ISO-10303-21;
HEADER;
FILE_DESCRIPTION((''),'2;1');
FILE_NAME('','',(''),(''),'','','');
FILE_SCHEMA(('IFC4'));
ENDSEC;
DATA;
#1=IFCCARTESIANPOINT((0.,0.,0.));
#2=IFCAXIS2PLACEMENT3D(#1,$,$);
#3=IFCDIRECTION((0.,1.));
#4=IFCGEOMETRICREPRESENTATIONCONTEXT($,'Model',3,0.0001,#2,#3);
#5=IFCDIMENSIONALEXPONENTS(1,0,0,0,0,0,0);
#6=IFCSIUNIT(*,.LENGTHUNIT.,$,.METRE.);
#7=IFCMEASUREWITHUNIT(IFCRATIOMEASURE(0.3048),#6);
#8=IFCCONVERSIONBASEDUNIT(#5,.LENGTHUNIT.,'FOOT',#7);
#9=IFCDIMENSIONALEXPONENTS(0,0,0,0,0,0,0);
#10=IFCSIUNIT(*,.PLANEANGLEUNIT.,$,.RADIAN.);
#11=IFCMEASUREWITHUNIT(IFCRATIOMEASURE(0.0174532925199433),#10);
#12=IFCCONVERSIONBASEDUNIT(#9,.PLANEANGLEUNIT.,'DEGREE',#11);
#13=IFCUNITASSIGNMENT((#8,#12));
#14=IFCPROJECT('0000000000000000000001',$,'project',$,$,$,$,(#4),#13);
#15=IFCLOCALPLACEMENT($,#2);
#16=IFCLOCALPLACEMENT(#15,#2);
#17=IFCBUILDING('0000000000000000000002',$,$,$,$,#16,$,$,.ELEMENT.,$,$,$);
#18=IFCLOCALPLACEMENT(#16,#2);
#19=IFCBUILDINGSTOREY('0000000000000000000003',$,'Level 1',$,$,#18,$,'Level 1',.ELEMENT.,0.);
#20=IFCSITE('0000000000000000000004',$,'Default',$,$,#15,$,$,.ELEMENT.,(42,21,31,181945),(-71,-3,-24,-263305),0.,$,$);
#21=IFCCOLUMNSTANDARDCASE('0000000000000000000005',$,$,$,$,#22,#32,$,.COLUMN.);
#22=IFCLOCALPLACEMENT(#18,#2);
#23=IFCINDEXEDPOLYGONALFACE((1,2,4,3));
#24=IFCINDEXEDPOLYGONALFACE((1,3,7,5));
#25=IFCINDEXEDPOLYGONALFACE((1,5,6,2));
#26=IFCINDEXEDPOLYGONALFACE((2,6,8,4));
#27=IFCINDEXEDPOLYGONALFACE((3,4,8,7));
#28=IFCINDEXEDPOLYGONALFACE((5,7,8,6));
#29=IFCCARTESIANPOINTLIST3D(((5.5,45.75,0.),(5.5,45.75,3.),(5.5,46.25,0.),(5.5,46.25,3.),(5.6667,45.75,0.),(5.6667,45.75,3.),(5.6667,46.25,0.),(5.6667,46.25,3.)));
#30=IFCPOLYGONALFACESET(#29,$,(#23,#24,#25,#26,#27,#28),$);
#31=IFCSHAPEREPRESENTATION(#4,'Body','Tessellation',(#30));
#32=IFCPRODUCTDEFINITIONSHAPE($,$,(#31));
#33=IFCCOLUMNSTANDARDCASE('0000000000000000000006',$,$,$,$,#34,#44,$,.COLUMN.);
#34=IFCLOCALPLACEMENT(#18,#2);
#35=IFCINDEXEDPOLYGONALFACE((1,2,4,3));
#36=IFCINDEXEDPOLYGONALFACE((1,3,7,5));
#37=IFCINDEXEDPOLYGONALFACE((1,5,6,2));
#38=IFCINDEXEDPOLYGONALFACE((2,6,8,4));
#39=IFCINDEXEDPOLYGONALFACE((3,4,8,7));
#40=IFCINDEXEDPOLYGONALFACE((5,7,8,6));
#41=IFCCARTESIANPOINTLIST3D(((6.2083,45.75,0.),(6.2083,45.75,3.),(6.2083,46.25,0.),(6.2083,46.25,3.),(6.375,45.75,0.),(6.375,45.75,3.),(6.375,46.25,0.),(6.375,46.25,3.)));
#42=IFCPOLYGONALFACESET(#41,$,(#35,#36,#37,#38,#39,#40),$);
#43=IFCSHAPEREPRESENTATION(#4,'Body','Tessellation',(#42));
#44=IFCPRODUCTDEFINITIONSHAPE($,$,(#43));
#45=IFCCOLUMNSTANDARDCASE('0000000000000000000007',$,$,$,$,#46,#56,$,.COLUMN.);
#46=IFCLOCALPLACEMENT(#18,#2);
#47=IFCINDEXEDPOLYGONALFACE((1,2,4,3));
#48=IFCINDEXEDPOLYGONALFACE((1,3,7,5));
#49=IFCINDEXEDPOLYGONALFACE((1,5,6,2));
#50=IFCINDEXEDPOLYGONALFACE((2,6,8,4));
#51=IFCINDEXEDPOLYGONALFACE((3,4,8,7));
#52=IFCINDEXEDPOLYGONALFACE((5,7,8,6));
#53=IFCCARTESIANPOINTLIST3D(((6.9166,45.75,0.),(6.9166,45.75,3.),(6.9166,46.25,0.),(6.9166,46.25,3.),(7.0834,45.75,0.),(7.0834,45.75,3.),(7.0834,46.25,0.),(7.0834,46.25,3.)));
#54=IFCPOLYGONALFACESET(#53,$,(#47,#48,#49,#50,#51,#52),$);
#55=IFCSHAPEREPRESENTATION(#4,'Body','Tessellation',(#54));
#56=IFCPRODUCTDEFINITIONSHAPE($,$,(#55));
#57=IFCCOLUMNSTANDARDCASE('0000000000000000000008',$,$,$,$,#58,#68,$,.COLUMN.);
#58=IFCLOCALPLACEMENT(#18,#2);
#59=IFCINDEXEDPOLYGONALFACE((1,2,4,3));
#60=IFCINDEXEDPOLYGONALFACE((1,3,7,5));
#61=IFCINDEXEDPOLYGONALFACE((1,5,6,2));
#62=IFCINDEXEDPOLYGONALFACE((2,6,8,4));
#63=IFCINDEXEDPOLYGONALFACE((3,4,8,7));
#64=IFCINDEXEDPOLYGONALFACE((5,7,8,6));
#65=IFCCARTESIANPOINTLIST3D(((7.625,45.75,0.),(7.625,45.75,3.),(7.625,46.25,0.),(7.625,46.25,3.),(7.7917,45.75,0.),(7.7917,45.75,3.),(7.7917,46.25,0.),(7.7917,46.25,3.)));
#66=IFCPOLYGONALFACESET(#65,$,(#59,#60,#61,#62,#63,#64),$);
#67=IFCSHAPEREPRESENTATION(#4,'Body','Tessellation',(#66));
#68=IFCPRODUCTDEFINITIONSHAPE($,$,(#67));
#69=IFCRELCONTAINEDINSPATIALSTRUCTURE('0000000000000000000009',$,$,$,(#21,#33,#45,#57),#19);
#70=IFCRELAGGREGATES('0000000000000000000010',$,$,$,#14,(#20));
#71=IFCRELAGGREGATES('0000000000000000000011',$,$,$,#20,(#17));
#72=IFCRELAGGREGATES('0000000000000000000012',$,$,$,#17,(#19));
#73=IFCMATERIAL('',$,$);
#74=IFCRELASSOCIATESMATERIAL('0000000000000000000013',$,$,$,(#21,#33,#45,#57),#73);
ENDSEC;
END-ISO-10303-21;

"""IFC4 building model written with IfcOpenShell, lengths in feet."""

from ifc_helpers import new_model, entity, si_unit, converted_unit, direction, frame, origin, place, context, project, spatial, rectangle, extrude, material, element, save


model = new_model("IFC4")

# Units and contexts
model_context = context("Model", 3, precision=0.0001, world=origin(), true_north=direction((0.0, 1.0)))
ifc_project = project(units=[converted_unit("LENGTHUNIT", "FOOT", entity("IfcRatioMeasure", 0.3048), si_unit("LENGTHUNIT", "METRE"), dimensions=[1, 0, 0, 0, 0, 0, 0]), converted_unit("PLANEANGLEUNIT", "DEGREE", entity("IfcRatioMeasure", 0.0174532925199433), si_unit("PLANEANGLEUNIT", "RADIAN"), dimensions=[0, 0, 0, 0, 0, 0, 0])], contexts=[model_context])

# Site, building, storey
site_placement = place(None, origin())
site = spatial("IfcSite", under=ifc_project, at=site_placement, Name="Default", CompositionType="ELEMENT", RefLatitude=(42, 21, 31, 181945), RefLongitude=(-71, -3, -24, -263305), RefElevation=0.0)
building_placement = place(site_placement, origin())
building = spatial("IfcBuilding", under=site, at=building_placement, CompositionType="ELEMENT")
storey_placement = place(building_placement, origin())
storey = spatial("IfcBuildingStorey", under=building, at=storey_placement, Name="Level 1", LongName="Level 1", CompositionType="ELEMENT", Elevation=0.0)

# Columns
placement_1 = place(storey_placement, frame((-0.25, 46.0, 0.0)))
ifc_material_1 = material(Name="")
for number, where, z_axis, x_axis in (
    (1, (5.8334, 0.0, 0.0), (0.0, 0.0, 1.0), (1.0, 0.0, 0.0)),
    (2, (6.5417, 0.0, 0.0), (0.0, 0.0, 1.0), (1.0, 0.0, 0.0)),
    (3, (7.25, 0.0, 0.0), (0.0, 0.0, 1.0), (1.0, 0.0, 0.0)),
    (4, (7.9583, 0.0, 0.0), (0.0, 0.0, 1.0), (1.0, 0.0, 0.0)),
):
    element("IfcColumnStandardCase", number, at=place(placement_1, frame(where, z_axis=z_axis, x_axis=x_axis)), inside=storey, material=ifc_material_1, PredefinedType="COLUMN", context=model_context, shape_type="SweptSolid", body=[
        extrude(rectangle(XDim=0.1667, YDim=0.5), origin(), (0.0, 0.0, 1.0), 3.0),
    ])

save(model, "model.ifc")
